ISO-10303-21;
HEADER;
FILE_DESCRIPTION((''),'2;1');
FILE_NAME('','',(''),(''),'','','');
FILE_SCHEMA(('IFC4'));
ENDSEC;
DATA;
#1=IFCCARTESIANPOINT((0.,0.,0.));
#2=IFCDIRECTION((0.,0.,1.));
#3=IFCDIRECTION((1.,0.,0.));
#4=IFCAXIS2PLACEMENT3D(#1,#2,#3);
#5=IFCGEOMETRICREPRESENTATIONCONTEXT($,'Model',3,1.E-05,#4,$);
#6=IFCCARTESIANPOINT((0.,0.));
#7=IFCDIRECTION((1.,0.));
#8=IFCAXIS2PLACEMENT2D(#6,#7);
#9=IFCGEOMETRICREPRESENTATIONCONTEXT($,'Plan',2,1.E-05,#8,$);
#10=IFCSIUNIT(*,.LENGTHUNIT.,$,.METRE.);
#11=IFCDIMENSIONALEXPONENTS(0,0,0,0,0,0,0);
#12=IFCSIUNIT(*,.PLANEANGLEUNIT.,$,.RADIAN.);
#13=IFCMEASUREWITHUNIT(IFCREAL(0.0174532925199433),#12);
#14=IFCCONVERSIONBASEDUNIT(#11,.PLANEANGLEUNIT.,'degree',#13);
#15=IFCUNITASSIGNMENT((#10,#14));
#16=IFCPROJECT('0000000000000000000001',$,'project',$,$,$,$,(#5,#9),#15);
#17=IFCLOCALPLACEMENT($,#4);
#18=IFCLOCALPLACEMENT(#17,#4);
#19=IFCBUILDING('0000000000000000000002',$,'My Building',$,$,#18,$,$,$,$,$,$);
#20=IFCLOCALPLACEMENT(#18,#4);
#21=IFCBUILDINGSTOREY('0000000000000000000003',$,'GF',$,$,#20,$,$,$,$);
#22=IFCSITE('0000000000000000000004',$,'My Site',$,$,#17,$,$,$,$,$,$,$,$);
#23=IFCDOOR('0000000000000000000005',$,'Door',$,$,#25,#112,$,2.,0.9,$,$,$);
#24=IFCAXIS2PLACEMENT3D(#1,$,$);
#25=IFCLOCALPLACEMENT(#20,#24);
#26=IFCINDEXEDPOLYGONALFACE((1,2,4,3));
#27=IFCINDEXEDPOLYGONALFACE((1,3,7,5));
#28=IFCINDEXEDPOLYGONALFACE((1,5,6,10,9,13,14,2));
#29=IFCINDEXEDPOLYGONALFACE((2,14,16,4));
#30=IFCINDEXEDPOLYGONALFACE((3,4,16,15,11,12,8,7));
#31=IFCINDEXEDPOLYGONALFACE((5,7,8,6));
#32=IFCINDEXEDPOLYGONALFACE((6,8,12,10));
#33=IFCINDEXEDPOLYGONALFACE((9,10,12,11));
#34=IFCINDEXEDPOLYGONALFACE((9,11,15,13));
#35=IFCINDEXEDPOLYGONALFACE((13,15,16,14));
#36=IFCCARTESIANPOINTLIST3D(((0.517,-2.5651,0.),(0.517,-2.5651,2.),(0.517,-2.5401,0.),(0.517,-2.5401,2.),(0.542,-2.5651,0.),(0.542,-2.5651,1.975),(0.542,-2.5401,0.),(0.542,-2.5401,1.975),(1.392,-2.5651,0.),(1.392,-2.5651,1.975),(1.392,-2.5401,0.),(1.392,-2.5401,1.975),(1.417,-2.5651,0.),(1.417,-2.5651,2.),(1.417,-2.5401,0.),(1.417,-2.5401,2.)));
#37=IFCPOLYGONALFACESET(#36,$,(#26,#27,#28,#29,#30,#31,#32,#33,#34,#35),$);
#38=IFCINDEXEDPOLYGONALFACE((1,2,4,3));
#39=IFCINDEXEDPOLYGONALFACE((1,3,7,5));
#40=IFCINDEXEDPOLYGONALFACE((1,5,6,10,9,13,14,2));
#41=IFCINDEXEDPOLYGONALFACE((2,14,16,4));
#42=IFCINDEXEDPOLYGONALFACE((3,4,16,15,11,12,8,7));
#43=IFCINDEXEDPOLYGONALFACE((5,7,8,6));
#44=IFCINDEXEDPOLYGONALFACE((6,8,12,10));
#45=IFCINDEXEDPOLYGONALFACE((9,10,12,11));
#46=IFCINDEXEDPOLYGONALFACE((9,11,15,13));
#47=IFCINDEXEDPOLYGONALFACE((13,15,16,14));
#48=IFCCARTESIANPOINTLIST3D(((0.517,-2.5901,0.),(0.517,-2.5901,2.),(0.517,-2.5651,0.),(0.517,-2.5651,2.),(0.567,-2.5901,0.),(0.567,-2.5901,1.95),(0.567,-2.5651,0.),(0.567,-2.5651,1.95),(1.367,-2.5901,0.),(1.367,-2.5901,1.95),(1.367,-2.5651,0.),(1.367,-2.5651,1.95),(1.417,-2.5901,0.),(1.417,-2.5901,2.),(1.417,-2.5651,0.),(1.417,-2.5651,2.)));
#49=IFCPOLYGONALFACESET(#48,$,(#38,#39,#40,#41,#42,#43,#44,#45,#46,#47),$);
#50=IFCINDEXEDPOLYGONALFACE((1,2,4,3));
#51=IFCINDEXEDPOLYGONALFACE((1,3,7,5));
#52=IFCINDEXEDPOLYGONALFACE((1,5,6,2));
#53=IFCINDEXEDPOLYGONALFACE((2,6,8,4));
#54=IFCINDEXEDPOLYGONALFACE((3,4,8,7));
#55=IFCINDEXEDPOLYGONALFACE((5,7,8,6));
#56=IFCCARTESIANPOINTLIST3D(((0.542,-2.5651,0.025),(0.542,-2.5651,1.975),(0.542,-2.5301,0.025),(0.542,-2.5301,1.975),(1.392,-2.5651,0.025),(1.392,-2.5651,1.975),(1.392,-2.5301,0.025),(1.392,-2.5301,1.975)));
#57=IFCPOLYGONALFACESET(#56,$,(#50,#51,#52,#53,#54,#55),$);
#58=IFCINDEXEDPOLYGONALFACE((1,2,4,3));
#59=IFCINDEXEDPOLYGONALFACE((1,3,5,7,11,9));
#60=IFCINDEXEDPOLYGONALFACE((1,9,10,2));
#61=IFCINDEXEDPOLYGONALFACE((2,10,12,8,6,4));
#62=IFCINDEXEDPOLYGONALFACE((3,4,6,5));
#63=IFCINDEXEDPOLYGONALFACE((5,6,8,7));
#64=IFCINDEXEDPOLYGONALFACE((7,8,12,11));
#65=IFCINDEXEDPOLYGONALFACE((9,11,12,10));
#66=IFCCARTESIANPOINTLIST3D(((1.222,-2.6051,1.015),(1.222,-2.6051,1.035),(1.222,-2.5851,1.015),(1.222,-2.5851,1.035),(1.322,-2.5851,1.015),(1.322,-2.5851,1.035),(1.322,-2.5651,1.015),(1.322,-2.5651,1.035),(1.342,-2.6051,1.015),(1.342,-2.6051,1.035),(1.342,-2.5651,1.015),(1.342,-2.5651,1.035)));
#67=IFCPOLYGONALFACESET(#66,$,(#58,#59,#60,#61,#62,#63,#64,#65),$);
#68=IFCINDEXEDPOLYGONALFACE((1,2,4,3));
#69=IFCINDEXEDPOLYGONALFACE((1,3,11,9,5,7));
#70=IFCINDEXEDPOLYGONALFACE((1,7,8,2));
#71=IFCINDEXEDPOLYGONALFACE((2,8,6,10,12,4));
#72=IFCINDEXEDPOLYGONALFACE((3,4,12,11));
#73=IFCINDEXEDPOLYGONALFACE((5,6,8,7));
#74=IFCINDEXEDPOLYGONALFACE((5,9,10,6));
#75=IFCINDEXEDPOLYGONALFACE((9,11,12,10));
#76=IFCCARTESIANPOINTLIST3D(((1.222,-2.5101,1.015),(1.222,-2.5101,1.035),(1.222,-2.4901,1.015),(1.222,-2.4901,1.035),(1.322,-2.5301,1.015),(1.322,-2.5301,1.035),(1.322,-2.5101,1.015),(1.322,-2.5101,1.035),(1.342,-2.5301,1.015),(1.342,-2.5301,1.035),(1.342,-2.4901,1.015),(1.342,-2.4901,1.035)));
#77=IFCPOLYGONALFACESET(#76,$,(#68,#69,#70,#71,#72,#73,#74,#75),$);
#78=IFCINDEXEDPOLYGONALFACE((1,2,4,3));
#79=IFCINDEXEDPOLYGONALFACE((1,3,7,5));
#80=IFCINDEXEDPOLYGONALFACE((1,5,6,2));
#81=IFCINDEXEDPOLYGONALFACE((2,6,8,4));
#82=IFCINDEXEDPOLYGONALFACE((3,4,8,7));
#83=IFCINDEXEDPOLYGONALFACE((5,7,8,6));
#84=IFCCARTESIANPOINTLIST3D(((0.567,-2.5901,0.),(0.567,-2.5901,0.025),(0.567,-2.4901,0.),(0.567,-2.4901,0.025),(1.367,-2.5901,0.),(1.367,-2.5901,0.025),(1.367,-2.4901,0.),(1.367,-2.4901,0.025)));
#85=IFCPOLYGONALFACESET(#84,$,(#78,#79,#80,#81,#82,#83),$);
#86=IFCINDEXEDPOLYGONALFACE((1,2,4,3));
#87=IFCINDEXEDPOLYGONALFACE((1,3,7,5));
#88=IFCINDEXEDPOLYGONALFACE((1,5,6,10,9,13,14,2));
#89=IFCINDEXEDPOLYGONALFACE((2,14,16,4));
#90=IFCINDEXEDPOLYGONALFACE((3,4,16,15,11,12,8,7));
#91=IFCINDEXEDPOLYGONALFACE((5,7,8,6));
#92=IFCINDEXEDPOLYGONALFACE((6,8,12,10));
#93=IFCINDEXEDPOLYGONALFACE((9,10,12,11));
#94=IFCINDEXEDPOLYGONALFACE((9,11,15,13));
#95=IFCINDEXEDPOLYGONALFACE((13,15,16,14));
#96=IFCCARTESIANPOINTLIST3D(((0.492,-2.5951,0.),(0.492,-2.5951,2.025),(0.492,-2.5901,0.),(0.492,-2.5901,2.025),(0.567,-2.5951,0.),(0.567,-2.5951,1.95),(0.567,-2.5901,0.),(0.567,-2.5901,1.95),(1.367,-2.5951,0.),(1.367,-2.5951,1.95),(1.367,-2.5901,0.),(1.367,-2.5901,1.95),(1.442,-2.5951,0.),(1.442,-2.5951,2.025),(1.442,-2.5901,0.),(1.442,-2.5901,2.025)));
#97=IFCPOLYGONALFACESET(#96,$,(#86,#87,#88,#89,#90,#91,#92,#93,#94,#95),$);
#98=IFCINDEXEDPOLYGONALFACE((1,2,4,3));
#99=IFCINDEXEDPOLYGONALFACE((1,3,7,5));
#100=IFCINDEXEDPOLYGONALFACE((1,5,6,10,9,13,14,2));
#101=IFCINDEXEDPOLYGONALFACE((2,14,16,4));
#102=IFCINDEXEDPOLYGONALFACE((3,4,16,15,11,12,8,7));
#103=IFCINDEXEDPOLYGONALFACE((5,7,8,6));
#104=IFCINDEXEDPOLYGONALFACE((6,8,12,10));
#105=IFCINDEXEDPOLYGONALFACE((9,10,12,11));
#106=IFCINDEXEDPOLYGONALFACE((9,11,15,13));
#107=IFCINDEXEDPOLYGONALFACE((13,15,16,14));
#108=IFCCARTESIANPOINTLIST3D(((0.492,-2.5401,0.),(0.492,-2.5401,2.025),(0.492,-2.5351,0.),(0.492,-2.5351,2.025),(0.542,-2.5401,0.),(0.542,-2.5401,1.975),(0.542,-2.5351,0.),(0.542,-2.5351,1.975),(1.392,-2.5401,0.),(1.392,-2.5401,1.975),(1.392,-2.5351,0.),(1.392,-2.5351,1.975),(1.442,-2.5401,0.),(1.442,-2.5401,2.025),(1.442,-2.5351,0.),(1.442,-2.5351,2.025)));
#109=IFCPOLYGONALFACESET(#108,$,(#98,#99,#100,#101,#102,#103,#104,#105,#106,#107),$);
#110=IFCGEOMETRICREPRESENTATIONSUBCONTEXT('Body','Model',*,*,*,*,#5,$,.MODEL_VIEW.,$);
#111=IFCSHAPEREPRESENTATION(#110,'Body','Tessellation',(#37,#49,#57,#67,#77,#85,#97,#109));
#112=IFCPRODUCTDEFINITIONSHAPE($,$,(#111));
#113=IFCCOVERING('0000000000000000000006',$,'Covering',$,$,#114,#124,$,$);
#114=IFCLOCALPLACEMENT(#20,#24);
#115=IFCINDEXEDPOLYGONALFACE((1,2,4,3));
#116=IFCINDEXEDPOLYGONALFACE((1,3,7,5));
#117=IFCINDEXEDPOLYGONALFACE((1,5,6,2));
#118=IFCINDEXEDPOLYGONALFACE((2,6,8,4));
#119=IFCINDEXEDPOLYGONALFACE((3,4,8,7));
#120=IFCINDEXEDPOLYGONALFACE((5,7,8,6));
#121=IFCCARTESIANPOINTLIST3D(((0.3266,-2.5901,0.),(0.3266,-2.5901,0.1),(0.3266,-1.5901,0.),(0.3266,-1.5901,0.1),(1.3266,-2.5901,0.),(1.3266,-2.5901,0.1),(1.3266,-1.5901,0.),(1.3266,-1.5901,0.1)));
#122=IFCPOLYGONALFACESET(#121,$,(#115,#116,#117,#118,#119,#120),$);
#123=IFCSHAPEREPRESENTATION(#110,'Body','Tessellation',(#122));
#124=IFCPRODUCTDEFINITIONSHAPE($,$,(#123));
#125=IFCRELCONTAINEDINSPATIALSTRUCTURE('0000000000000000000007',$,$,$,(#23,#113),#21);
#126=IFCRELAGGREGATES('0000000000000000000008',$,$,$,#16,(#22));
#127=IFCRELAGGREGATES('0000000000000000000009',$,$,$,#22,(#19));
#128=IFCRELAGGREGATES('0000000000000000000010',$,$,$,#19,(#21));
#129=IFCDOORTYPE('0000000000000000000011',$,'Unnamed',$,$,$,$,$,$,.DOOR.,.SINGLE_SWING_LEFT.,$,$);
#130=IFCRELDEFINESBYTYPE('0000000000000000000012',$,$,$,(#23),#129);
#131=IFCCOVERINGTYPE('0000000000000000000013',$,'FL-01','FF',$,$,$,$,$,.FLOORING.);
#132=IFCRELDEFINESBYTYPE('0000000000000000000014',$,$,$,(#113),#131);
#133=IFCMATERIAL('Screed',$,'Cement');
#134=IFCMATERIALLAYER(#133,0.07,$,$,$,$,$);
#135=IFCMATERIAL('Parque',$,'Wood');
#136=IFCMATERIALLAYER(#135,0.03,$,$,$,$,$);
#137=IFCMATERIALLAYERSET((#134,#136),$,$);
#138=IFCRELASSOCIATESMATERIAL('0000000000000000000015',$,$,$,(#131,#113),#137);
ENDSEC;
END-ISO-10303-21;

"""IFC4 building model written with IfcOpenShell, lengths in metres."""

from ifc_helpers import new_model, entity, si_unit, converted_unit, frame, origin_with_axes, origin_2d_with_axis, place, context, subcontext, project, spatial, line, indexed_curve, outline, extrude, shape, source, transform, mapped, material, layer, layer_set, layer_usage, type_object, type_shapes, element, save


model = new_model("IFC4")

# Units and contexts
model_context = context("Model", 3, precision=1e-05, world=origin_with_axes())
plan_context = context("Plan", 2, precision=1e-05, world=origin_2d_with_axis())
body_context_1 = subcontext(model_context, "Body", "Model", "MODEL_VIEW")
body_context_2 = subcontext(plan_context, "Body", "Plan", "PLAN_VIEW")
ifc_project = project(units=[si_unit("LENGTHUNIT", "METRE"), converted_unit("PLANEANGLEUNIT", "degree", entity("IfcReal", 0.0174532925199433), si_unit("PLANEANGLEUNIT", "RADIAN"), dimensions=[0, 0, 0, 0, 0, 0, 0])], contexts=[model_context, plan_context])

# Site, building, storey
site_placement = place(None, origin_with_axes())
site = spatial("IfcSite", under=ifc_project, at=site_placement, Name="My Site")
building_placement = place(site_placement, origin_with_axes())
building = spatial("IfcBuilding", under=site, at=building_placement, Name="My Building")
storey_placement = place(building_placement, origin_with_axes())
storey = spatial("IfcBuildingStorey", under=building, at=storey_placement, Name="GF")

# Shared definitions
door_type = type_object("IfcDoorType", Name="Unnamed", OperationType="SINGLE_SWING_LEFT", PredefinedType="DOOR")
shared_shape_1 = source(origin_with_axes(), body_context_1, "Body", "SweptSolid", [
    extrude(outline(indexed_curve([(0.0, 0.0), (0.0, 2.0), (0.9, 2.0), (0.9, 0.0), (0.875, 0.0), (0.875, 1.975), (0.025, 1.975), (0.025, 0.0)], segments=[line(1, 2, 3, 4, 5, 6, 7, 8, 1)])), frame((0.0, 0.025, 0.0), z_axis=(0.0, -1.0, 0.0), x_axis=(1.0, 0.0, 0.0)), (0.0, 0.0, -1.0), 0.025),
    extrude(outline(indexed_curve([(0.0, 0.0), (0.0, 2.0), (0.9, 2.0), (0.9, 0.0), (0.85, 0.0), (0.85, 1.95), (0.05, 1.95), (0.05, 0.0)], segments=[line(1, 2, 3, 4, 5, 6, 7, 8, 1)])), frame((0.0, 0.0, 0.0), z_axis=(0.0, -1.0, 0.0), x_axis=(1.0, 0.0, 0.0)), (0.0, 0.0, -1.0), 0.025),
    extrude(outline(indexed_curve([(0.0, 0.0), (0.85, 0.0), (0.85, 0.035), (0.0, 0.035)], segments=[line(1, 2, 3, 4, 1)])), frame((0.025, 0.025, 0.025), z_axis=(0.0, 0.0, 1.0), x_axis=(1.0, 0.0, 0.0)), (0.0, 0.0, 1.0), 1.95),
    extrude(outline(indexed_curve([(0.0, 0.0), (0.0, -0.04), (-0.12, -0.04), (-0.12, -0.02), (-0.02, -0.02), (-0.02, 0.0)], segments=[line(1, 2, 3, 4, 5, 6, 1)])), frame((0.825, 0.025, 1.015), z_axis=(0.0, 0.0, 1.0), x_axis=(1.0, 0.0, 0.0)), (0.0, 0.0, 1.0), 0.02),
    extrude(outline(indexed_curve([(0.0, 0.0), (0.0, 0.04), (-0.12, 0.04), (-0.12, 0.02), (-0.02, 0.02), (-0.02, 0.0)], segments=[line(1, 2, 3, 4, 5, 6, 1)])), frame((0.825, 0.06, 1.015), z_axis=(0.0, 0.0, 1.0), x_axis=(1.0, 0.0, 0.0)), (0.0, 0.0, 1.0), 0.02),
    extrude(outline(indexed_curve([(0.0, 0.0), (0.8, 0.0), (0.8, 0.1), (0.0, 0.1)], segments=[line(1, 2, 3, 4, 1)])), frame((0.05, 0.0, 0.0), z_axis=(0.0, 0.0, 1.0), x_axis=(1.0, 0.0, 0.0)), (0.0, 0.0, 1.0), 0.025),
    extrude(outline(indexed_curve([(0.0, 0.0), (0.0, 2.025), (0.95, 2.025), (0.95, 0.0), (0.875, 0.0), (0.875, 1.95), (0.075, 1.95), (0.075, 0.0)], segments=[line(1, 2, 3, 4, 5, 6, 7, 8, 1)])), frame((-0.025, -0.005, 0.0), z_axis=(0.0, -1.0, 0.0), x_axis=(1.0, 0.0, 0.0)), (0.0, 0.0, -1.0), 0.005),
    extrude(outline(indexed_curve([(0.0, 0.0), (0.0, 2.025), (0.95, 2.025), (0.95, 0.0), (0.9, 0.0), (0.9, 1.975), (0.05, 1.975), (0.05, 0.0)], segments=[line(1, 2, 3, 4, 5, 6, 7, 8, 1)])), frame((-0.025, 0.05, 0.0), z_axis=(0.0, -1.0, 0.0), x_axis=(1.0, 0.0, 0.0)), (0.0, 0.0, -1.0), 0.005),
])
shared_shape_2 = source(origin_with_axes(), body_context_2, "Body", "Curve2D", [
    entity("IfcIndexedPolyCurve", entity("IfcCartesianPointList2D", [[0.0, 0.0], [0.0, 0.05], [0.025, 0.05], [0.025, 0.025], [0.05, 0.025], [0.05, 0.0]]), [entity("IfcLineIndex", [1, 2, 3, 4, 5, 6, 1])]),
    entity("IfcIndexedPolyCurve", entity("IfcCartesianPointList2D", [[0.9, 0.0], [0.9, 0.05], [0.875, 0.05], [0.875, 0.025], [0.85, 0.025], [0.85, 0.0]]), [entity("IfcLineIndex", [1, 2, 3, 4, 5, 6, 1])]),
    entity("IfcTrimmedCurve", entity("IfcEllipse", entity("IfcAxis2Placement2D", entity("IfcCartesianPoint", [0.06, 0.05]), entity("IfcDirection", [1.0, 0.0])), 0.815, 0.85), [entity("IfcCartesianPoint", [0.875, 0.05])], [entity("IfcCartesianPoint", [0.06, 0.9])], True, "CARTESIAN"),
    entity("IfcIndexedPolyCurve", entity("IfcCartesianPointList2D", [[0.025, 0.05], [0.06, 0.05], [0.06, 0.9], [0.025, 0.9]]), [entity("IfcLineIndex", [1, 2, 3, 4, 1])]),
])
type_shapes(door_type, [shared_shape_1, shared_shape_2])

# Door
placement_1 = place(storey_placement, frame((0.2266, -2.5901, 0.0), z_axis=(0.0, 0.0, 1.0), x_axis=(1.0, 0.0, 0.0)))
placement_2 = place(placement_1, frame((0.2904, 0.0, 0.0), z_axis=(0.0, 0.0, 1.0), x_axis=(1.0, 0.0, 0.0)))
door_1_placement = place(placement_2, origin_with_axes())
element("IfcDoor", 1, at=door_1_placement, inside=storey, type_object=door_type, Name="Door", OverallHeight=2.0, OverallWidth=0.9, shapes=[
    shape(body_context_1, "Body", "MappedRepresentation", [mapped(shared_shape_1, transform((0.0, 0.0, 0.0), x_axis=(1.0, 0.0, 0.0), y_axis=(0.0, 1.0, 0.0), z_axis=(0.0, 0.0, 1.0), scale=1.0))]),
    shape(body_context_2, "Body", "MappedRepresentation", [mapped(shared_shape_2, transform((0.0, 0.0, 0.0), x_axis=(1.0, 0.0, 0.0), y_axis=(0.0, 1.0, 0.0), z_axis=(0.0, 0.0, 1.0), scale=1.0))]),
])

# Covering
ifc_material_1 = material(Name="Screed", Category="Cement")
ifc_layer_1 = layer(ifc_material_1, 0.07)
ifc_material_2 = material(Name="Parque", Category="Wood")
ifc_layer_2 = layer(ifc_material_2, 0.03)
ifc_layer_set_1 = layer_set([ifc_layer_1, ifc_layer_2])
ifc_layer_usage_1 = layer_usage(ifc_layer_set_1, "AXIS3", "POSITIVE", 0.0)
covering_type = type_object("IfcCoveringType", Name="FL-01", Description="FF", PredefinedType="FLOORING", material=ifc_layer_set_1)
covering_placement = place(storey_placement, frame((0.3266, -2.5901, 0.0), z_axis=(0.0, 0.0, 1.0), x_axis=(1.0, 0.0, 0.0)))
element("IfcCovering", 2, at=covering_placement, inside=storey, type_object=covering_type, material=ifc_layer_usage_1, Name="Covering", context=body_context_1, shape_type="SweptSolid", body=[
    extrude(outline(indexed_curve([(0.0, 0.0), (1.0, 0.0), (1.0, 1.0), (0.0, 1.0), (0.0, 0.0)])), None, (0.0, 0.0, 1.0), 0.1),
])

save(model, "model.ifc")
